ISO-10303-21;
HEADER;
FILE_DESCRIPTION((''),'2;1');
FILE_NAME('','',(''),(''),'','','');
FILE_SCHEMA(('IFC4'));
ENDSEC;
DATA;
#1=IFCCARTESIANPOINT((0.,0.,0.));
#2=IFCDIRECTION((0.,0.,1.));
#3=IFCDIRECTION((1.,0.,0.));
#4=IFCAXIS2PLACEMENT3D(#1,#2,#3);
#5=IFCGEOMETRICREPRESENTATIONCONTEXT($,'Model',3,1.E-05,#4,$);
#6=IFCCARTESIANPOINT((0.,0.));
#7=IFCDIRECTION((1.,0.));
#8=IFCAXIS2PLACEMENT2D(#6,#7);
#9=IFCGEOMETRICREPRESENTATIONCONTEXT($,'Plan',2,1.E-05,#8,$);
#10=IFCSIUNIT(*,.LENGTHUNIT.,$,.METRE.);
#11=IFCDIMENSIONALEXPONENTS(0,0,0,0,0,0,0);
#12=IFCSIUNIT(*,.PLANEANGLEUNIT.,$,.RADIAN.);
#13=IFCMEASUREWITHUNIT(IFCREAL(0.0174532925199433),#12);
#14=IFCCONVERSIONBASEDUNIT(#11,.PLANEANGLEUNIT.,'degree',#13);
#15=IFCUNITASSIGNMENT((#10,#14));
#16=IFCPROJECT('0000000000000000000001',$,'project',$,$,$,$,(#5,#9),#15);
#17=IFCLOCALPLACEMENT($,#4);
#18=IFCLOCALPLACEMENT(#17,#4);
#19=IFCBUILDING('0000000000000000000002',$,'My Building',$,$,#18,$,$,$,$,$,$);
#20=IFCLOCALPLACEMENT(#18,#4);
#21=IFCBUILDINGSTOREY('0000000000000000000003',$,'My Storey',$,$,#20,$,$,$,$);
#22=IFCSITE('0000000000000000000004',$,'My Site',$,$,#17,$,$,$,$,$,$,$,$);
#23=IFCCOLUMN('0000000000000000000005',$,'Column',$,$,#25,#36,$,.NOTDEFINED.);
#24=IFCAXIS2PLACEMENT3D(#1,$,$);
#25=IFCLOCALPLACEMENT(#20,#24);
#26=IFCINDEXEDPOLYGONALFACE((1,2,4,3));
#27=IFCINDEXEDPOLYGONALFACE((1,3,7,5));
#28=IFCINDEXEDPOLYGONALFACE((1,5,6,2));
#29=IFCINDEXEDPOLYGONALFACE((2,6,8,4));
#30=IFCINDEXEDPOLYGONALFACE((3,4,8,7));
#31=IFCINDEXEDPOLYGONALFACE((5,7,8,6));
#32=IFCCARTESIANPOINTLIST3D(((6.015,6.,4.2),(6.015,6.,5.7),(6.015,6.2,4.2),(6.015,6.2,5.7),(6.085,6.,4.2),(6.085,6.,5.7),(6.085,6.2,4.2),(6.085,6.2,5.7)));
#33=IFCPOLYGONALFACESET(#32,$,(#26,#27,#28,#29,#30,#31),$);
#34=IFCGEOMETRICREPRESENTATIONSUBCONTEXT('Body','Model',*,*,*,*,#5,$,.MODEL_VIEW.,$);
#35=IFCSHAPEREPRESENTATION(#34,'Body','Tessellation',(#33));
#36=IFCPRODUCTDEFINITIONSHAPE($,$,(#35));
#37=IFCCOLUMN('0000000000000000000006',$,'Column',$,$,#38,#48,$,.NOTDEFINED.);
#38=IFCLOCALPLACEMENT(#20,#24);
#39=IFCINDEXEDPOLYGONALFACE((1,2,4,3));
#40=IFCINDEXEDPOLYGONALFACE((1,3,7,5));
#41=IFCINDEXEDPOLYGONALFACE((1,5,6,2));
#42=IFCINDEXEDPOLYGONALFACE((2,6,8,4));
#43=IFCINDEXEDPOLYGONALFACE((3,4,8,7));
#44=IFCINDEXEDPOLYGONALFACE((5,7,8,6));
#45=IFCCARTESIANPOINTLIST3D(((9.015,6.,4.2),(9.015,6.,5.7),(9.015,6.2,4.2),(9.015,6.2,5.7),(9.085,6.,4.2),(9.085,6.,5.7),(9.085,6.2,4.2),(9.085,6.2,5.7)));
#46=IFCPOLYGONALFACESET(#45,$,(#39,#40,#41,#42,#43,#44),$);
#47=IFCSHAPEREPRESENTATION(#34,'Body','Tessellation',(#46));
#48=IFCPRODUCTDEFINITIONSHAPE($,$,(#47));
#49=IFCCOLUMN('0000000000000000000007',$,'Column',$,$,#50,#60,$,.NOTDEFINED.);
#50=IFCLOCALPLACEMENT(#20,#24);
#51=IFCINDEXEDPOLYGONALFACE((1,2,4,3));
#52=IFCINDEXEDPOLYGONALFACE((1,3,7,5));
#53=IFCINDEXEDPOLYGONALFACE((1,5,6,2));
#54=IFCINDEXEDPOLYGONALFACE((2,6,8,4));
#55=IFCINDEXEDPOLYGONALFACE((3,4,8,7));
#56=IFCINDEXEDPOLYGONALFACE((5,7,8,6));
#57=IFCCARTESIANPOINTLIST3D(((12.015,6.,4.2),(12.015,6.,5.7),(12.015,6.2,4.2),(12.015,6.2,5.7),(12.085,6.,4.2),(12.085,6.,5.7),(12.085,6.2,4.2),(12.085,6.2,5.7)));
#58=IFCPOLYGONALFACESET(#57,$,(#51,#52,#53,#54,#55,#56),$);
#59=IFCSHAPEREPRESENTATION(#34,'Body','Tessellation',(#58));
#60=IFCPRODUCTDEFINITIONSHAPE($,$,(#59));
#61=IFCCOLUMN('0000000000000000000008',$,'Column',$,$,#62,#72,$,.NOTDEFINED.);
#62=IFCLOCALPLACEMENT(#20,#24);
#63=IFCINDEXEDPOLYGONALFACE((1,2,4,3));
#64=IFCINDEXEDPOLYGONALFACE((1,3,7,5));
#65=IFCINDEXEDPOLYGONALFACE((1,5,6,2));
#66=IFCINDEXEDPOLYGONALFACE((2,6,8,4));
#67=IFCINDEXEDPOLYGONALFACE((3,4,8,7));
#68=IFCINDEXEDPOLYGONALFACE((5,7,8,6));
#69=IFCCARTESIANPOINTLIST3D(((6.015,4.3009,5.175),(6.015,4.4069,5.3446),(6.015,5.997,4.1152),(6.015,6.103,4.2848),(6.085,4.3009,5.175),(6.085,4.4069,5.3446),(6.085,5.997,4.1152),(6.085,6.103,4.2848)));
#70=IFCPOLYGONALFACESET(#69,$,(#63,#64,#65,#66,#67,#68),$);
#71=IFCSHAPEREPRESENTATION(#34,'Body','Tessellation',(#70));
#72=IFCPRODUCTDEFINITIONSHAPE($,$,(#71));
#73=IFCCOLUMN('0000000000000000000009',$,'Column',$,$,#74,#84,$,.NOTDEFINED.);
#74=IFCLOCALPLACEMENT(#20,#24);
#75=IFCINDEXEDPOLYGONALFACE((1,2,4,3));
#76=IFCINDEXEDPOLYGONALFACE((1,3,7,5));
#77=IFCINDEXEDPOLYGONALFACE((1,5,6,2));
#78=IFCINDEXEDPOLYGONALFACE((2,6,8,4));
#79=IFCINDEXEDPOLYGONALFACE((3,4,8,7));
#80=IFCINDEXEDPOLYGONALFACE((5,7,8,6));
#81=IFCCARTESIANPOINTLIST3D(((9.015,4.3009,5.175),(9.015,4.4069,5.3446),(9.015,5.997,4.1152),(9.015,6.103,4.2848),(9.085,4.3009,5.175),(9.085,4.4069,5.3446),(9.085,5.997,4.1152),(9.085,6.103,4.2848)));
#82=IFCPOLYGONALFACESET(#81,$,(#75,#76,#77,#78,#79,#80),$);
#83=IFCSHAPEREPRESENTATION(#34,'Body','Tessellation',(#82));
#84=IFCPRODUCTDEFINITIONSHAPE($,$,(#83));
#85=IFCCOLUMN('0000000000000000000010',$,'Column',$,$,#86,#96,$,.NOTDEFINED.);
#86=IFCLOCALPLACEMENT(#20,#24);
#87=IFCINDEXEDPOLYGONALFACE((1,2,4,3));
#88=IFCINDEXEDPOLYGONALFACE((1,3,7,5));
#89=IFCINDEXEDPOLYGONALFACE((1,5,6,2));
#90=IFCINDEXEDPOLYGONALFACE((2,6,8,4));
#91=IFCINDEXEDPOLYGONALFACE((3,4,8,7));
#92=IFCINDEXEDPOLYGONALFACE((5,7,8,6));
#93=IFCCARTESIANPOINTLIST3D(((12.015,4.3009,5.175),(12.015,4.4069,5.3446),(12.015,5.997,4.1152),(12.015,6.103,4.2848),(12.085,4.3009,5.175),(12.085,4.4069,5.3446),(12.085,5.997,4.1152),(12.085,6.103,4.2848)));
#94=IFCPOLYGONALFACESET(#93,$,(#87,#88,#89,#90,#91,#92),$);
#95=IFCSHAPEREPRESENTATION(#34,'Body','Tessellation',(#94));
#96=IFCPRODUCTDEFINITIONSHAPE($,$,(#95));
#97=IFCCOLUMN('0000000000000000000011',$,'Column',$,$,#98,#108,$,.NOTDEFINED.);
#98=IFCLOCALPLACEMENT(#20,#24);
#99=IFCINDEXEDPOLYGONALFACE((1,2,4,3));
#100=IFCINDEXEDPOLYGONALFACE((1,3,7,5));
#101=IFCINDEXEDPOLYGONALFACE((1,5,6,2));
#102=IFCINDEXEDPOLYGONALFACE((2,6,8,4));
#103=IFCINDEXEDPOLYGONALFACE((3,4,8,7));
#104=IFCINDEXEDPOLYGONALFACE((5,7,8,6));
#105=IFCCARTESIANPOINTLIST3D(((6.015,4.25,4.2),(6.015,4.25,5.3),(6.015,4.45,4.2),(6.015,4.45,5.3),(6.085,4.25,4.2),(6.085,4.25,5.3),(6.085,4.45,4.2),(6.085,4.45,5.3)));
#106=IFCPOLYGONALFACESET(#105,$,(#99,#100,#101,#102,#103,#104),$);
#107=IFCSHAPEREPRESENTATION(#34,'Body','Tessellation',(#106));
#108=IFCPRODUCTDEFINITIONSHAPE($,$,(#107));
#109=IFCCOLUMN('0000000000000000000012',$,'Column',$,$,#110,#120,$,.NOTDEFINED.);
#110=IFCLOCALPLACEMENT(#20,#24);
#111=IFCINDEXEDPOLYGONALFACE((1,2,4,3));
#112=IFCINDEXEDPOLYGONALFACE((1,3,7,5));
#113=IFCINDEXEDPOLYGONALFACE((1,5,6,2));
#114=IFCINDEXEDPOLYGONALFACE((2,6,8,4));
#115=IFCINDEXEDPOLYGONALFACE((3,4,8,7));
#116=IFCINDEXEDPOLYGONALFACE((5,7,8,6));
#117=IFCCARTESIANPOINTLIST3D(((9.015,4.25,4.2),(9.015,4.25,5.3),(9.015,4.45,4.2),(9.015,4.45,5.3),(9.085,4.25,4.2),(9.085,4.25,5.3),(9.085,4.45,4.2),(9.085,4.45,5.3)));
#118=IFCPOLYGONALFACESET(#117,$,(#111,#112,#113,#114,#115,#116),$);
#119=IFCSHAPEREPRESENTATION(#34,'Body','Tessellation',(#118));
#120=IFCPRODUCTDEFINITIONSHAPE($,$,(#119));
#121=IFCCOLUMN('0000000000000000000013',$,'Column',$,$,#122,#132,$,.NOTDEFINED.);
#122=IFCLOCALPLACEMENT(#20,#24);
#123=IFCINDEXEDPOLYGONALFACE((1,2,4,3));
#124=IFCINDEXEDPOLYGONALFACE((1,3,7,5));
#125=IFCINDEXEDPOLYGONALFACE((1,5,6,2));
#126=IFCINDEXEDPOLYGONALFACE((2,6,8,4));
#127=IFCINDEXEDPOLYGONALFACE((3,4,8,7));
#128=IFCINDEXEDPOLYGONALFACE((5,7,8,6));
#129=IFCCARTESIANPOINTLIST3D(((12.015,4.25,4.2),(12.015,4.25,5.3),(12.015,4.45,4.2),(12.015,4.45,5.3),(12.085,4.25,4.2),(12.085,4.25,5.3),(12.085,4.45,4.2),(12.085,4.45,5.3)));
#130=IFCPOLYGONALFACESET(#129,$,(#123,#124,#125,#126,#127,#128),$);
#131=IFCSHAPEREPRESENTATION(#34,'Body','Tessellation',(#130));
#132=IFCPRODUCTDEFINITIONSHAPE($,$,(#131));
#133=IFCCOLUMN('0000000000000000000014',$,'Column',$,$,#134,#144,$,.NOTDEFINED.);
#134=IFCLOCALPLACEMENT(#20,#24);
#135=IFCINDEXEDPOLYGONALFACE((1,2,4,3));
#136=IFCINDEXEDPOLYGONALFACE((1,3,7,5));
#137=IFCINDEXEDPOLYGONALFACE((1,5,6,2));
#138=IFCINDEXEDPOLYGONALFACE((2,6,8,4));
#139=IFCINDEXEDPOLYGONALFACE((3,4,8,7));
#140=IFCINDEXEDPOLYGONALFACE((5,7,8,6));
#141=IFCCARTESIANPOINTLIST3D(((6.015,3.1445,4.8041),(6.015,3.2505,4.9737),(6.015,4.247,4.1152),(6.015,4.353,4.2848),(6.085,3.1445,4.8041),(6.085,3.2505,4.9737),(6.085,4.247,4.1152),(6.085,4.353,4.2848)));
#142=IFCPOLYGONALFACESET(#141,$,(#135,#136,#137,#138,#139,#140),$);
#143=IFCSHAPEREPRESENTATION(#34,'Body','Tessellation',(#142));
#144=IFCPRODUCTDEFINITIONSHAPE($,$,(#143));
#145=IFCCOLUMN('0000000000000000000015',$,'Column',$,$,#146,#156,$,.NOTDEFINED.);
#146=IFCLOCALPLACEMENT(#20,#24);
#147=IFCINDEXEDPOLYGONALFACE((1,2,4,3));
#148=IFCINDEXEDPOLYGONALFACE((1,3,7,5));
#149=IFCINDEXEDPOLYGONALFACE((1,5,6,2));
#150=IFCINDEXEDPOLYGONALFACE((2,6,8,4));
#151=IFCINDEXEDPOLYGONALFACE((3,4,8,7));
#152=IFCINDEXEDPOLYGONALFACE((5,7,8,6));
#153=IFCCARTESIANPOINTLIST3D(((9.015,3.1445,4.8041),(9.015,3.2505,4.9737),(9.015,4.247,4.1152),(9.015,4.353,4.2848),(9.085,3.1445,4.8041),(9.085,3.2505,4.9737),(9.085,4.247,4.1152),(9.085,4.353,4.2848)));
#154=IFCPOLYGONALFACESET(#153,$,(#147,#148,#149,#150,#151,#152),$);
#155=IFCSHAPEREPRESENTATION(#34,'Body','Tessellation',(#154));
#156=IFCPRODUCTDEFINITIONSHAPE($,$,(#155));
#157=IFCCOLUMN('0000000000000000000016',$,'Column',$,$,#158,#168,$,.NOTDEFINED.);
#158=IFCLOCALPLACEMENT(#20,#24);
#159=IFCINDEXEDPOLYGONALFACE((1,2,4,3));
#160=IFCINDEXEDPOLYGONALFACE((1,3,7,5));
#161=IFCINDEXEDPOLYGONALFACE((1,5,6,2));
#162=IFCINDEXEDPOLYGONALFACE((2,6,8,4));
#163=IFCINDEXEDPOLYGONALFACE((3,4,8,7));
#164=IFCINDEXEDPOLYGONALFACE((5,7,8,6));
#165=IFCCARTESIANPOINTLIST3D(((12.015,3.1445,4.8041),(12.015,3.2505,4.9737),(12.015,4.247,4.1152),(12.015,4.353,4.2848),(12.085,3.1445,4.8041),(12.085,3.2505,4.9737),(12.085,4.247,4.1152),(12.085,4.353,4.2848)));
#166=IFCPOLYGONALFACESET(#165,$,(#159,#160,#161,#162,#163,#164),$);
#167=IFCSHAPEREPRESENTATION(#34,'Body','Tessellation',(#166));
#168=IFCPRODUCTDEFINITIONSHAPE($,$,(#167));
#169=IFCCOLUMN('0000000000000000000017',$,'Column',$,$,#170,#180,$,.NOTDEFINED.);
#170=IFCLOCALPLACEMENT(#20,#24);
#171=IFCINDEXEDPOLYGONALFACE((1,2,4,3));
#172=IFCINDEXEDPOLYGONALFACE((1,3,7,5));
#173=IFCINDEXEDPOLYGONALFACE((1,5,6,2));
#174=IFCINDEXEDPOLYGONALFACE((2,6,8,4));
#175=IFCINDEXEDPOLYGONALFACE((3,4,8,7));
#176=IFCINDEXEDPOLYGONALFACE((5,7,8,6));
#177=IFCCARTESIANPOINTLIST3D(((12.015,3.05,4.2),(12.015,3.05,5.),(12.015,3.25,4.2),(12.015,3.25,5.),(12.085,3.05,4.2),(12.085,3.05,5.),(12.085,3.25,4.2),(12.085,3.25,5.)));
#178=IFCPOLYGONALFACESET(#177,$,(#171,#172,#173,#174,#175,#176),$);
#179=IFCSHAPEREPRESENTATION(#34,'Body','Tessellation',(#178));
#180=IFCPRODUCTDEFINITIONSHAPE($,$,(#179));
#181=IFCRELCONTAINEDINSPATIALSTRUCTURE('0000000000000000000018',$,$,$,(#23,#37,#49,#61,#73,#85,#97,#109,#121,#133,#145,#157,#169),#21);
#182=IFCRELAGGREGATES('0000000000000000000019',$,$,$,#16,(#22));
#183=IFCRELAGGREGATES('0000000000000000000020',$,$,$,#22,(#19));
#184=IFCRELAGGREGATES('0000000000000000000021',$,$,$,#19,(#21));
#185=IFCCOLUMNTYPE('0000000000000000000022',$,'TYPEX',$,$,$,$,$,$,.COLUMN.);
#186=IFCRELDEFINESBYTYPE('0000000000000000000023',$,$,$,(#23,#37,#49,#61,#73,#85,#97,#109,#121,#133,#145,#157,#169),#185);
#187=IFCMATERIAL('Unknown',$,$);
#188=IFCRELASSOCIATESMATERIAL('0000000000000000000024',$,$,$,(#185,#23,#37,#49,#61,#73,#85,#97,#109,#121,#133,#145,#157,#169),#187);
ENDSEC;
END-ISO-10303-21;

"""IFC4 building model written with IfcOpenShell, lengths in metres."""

from ifc_helpers import new_model, entity, si_unit, converted_unit, frame, origin_with_axes, origin_2d_with_axis, place, context, subcontext, project, spatial, rectangle, extrude, material, material_profile, profile_set, profile_usage, type_object, element, save


model = new_model("IFC4")

# Units and contexts
model_context = context("Model", 3, precision=1e-05, world=origin_with_axes())
plan_context = context("Plan", 2, precision=1e-05, world=origin_2d_with_axis())
body_context = subcontext(model_context, "Body", "Model", "MODEL_VIEW")
ifc_project = project(units=[si_unit("LENGTHUNIT", "METRE"), converted_unit("PLANEANGLEUNIT", "degree", entity("IfcReal", 0.0174532925199433), si_unit("PLANEANGLEUNIT", "RADIAN"), dimensions=[0, 0, 0, 0, 0, 0, 0])], contexts=[model_context, plan_context])

# Site, building, storey
site_placement = place(None, origin_with_axes())
site = spatial("IfcSite", under=ifc_project, at=site_placement, Name="My Site")
building_placement = place(site_placement, origin_with_axes())
building = spatial("IfcBuilding", under=site, at=building_placement, Name="My Building")
storey_placement = place(building_placement, origin_with_axes())
storey = spatial("IfcBuildingStorey", under=building, at=storey_placement, Name="My Storey")

# Columns
ifc_material_1 = material(Name="Unknown")
ifc_material_profile_1 = material_profile(ifc_material_1, rectangle(XDim=0.07, YDim=0.2))
ifc_profile_set_1 = profile_set([ifc_material_profile_1])
ifc_profile_usage_1 = profile_usage(ifc_profile_set_1, cardinal=2)
column_type = type_object("IfcColumnType", Name="TYPEX", PredefinedType="COLUMN", material=ifc_profile_set_1)
column_1_placement = place(storey_placement, frame((6.05, 6.2, 4.2), z_axis=(0.0, 0.0, 1.0), x_axis=(-1.0, 0.0, 0.0)))
element("IfcColumn", 1, at=column_1_placement, inside=storey, type_object=column_type, material=ifc_profile_usage_1, Name="Column", PredefinedType="NOTDEFINED", context=body_context, shape_type="SweptSolid", body=[
    extrude(rectangle(XDim=0.07, YDim=0.2), frame((0.0, 0.1, 0.0), z_axis=(0.0, 0.0, 1.0), x_axis=(1.0, 0.0, 0.0)), (0.0, 0.0, 1.0), 1.5),
])
ifc_profile_usage_2 = profile_usage(ifc_profile_set_1, cardinal=2)
column_2_placement = place(storey_placement, frame((9.05, 6.2, 4.2), z_axis=(0.0, 0.0, 1.0), x_axis=(-1.0, 0.0, 0.0)))
element("IfcColumn", 2, at=column_2_placement, inside=storey, type_object=column_type, material=ifc_profile_usage_2, Name="Column", PredefinedType="NOTDEFINED", context=body_context, shape_type="SweptSolid", body=[
    extrude(rectangle(XDim=0.07, YDim=0.2), frame((0.0, 0.1, 0.0), z_axis=(0.0, 0.0, 1.0), x_axis=(1.0, 0.0, 0.0)), (0.0, 0.0, 1.0), 1.5),
])
ifc_profile_usage_3 = profile_usage(ifc_profile_set_1, cardinal=2)
column_3_placement = place(storey_placement, frame((12.05, 6.2, 4.2), z_axis=(0.0, 0.0, 1.0), x_axis=(-1.0, 0.0, 0.0)))
element("IfcColumn", 3, at=column_3_placement, inside=storey, type_object=column_type, material=ifc_profile_usage_3, Name="Column", PredefinedType="NOTDEFINED", context=body_context, shape_type="SweptSolid", body=[
    extrude(rectangle(XDim=0.07, YDim=0.2), frame((0.0, 0.1, 0.0), z_axis=(0.0, 0.0, 1.0), x_axis=(1.0, 0.0, 0.0)), (0.0, 0.0, 1.0), 1.5),
])
ifc_profile_usage_4 = profile_usage(ifc_profile_set_1, cardinal=5)
column_4_placement = place(storey_placement, frame((6.05, 6.05, 4.2), z_axis=(0.0, -0.848048, 0.529919), x_axis=(-1.0, 0.0, 0.0)))
element("IfcColumn", 4, at=column_4_placement, inside=storey, type_object=column_type, material=ifc_profile_usage_4, Name="Column", PredefinedType="NOTDEFINED", context=body_context, shape_type="SweptSolid", body=[
    extrude(rectangle(XDim=0.07, YDim=0.2), origin_with_axes(), (0.0, 0.0, 1.0), 2.0),
])
ifc_profile_usage_5 = profile_usage(ifc_profile_set_1, cardinal=5)
column_5_placement = place(storey_placement, frame((9.05, 6.05, 4.2), z_axis=(0.0, -0.848048, 0.529919), x_axis=(-1.0, 0.0, 0.0)))
element("IfcColumn", 5, at=column_5_placement, inside=storey, type_object=column_type, material=ifc_profile_usage_5, Name="Column", PredefinedType="NOTDEFINED", context=body_context, shape_type="SweptSolid", body=[
    extrude(rectangle(XDim=0.07, YDim=0.2), origin_with_axes(), (0.0, 0.0, 1.0), 2.0),
])
ifc_profile_usage_6 = profile_usage(ifc_profile_set_1, cardinal=5)
column_6_placement = place(storey_placement, frame((12.05, 6.05, 4.2), z_axis=(0.0, -0.848048, 0.529919), x_axis=(-1.0, 0.0, 0.0)))
element("IfcColumn", 6, at=column_6_placement, inside=storey, type_object=column_type, material=ifc_profile_usage_6, Name="Column", PredefinedType="NOTDEFINED", context=body_context, shape_type="SweptSolid", body=[
    extrude(rectangle(XDim=0.07, YDim=0.2), origin_with_axes(), (0.0, 0.0, 1.0), 2.0),
])
ifc_profile_usage_7 = profile_usage(ifc_profile_set_1, cardinal=2)
column_7_placement = place(storey_placement, frame((6.05, 4.45, 4.2), z_axis=(0.0, 0.0, 1.0), x_axis=(-1.0, 0.0, 0.0)))
element("IfcColumn", 7, at=column_7_placement, inside=storey, type_object=column_type, material=ifc_profile_usage_7, Name="Column", PredefinedType="NOTDEFINED", context=body_context, shape_type="SweptSolid", body=[
    extrude(rectangle(XDim=0.07, YDim=0.2), frame((0.0, 0.1, 0.0), z_axis=(0.0, 0.0, 1.0), x_axis=(1.0, 0.0, 0.0)), (0.0, 0.0, 1.0), 1.1),
])
ifc_profile_usage_8 = profile_usage(ifc_profile_set_1, cardinal=2)
column_8_placement = place(storey_placement, frame((9.05, 4.45, 4.2), z_axis=(0.0, 0.0, 1.0), x_axis=(-1.0, 0.0, 0.0)))
element("IfcColumn", 8, at=column_8_placement, inside=storey, type_object=column_type, material=ifc_profile_usage_8, Name="Column", PredefinedType="NOTDEFINED", context=body_context, shape_type="SweptSolid", body=[
    extrude(rectangle(XDim=0.07, YDim=0.2), frame((0.0, 0.1, 0.0), z_axis=(0.0, 0.0, 1.0), x_axis=(1.0, 0.0, 0.0)), (0.0, 0.0, 1.0), 1.1),
])
ifc_profile_usage_9 = profile_usage(ifc_profile_set_1, cardinal=2)
column_9_placement = place(storey_placement, frame((12.05, 4.45, 4.2), z_axis=(0.0, 0.0, 1.0), x_axis=(-1.0, 0.0, 0.0)))
element("IfcColumn", 9, at=column_9_placement, inside=storey, type_object=column_type, material=ifc_profile_usage_9, Name="Column", PredefinedType="NOTDEFINED", context=body_context, shape_type="SweptSolid", body=[
    extrude(rectangle(XDim=0.07, YDim=0.2), frame((0.0, 0.1, 0.0), z_axis=(0.0, 0.0, 1.0), x_axis=(1.0, 0.0, 0.0)), (0.0, 0.0, 1.0), 1.1),
])
ifc_profile_usage_10 = profile_usage(ifc_profile_set_1, cardinal=5)
column_10_placement = place(storey_placement, frame((6.05, 4.3, 4.2), z_axis=(0.0, -0.848048, 0.529919), x_axis=(-1.0, 0.0, 0.0)))
element("IfcColumn", 10, at=column_10_placement, inside=storey, type_object=column_type, material=ifc_profile_usage_10, Name="Column", PredefinedType="NOTDEFINED", context=body_context, shape_type="SweptSolid", body=[
    extrude(rectangle(XDim=0.07, YDim=0.2), origin_with_axes(), (0.0, 0.0, 1.0), 1.3),
])
ifc_profile_usage_11 = profile_usage(ifc_profile_set_1, cardinal=5)
column_11_placement = place(storey_placement, frame((9.05, 4.3, 4.2), z_axis=(0.0, -0.848048, 0.529919), x_axis=(-1.0, 0.0, 0.0)))
element("IfcColumn", 11, at=column_11_placement, inside=storey, type_object=column_type, material=ifc_profile_usage_11, Name="Column", PredefinedType="NOTDEFINED", context=body_context, shape_type="SweptSolid", body=[
    extrude(rectangle(XDim=0.07, YDim=0.2), origin_with_axes(), (0.0, 0.0, 1.0), 1.3),
])
ifc_profile_usage_12 = profile_usage(ifc_profile_set_1, cardinal=5)
column_12_placement = place(storey_placement, frame((12.05, 4.3, 4.2), z_axis=(0.0, -0.848048, 0.529919), x_axis=(-1.0, 0.0, 0.0)))
element("IfcColumn", 12, at=column_12_placement, inside=storey, type_object=column_type, material=ifc_profile_usage_12, Name="Column", PredefinedType="NOTDEFINED", context=body_context, shape_type="SweptSolid", body=[
    extrude(rectangle(XDim=0.07, YDim=0.2), origin_with_axes(), (0.0, 0.0, 1.0), 1.3),
])
ifc_profile_usage_13 = profile_usage(ifc_profile_set_1, cardinal=2)
column_13_placement = place(storey_placement, frame((12.05, 3.25, 4.2), z_axis=(0.0, 0.0, 1.0), x_axis=(-1.0, 0.0, 0.0)))
element("IfcColumn", 13, at=column_13_placement, inside=storey, type_object=column_type, material=ifc_profile_usage_13, Name="Column", PredefinedType="NOTDEFINED", context=body_context, shape_type="SweptSolid", body=[
    extrude(rectangle(XDim=0.07, YDim=0.2), frame((0.0, 0.1, 0.0), z_axis=(0.0, 0.0, 1.0), x_axis=(1.0, 0.0, 0.0)), (0.0, 0.0, 1.0), 0.8),
])

save(model, "model.ifc")
